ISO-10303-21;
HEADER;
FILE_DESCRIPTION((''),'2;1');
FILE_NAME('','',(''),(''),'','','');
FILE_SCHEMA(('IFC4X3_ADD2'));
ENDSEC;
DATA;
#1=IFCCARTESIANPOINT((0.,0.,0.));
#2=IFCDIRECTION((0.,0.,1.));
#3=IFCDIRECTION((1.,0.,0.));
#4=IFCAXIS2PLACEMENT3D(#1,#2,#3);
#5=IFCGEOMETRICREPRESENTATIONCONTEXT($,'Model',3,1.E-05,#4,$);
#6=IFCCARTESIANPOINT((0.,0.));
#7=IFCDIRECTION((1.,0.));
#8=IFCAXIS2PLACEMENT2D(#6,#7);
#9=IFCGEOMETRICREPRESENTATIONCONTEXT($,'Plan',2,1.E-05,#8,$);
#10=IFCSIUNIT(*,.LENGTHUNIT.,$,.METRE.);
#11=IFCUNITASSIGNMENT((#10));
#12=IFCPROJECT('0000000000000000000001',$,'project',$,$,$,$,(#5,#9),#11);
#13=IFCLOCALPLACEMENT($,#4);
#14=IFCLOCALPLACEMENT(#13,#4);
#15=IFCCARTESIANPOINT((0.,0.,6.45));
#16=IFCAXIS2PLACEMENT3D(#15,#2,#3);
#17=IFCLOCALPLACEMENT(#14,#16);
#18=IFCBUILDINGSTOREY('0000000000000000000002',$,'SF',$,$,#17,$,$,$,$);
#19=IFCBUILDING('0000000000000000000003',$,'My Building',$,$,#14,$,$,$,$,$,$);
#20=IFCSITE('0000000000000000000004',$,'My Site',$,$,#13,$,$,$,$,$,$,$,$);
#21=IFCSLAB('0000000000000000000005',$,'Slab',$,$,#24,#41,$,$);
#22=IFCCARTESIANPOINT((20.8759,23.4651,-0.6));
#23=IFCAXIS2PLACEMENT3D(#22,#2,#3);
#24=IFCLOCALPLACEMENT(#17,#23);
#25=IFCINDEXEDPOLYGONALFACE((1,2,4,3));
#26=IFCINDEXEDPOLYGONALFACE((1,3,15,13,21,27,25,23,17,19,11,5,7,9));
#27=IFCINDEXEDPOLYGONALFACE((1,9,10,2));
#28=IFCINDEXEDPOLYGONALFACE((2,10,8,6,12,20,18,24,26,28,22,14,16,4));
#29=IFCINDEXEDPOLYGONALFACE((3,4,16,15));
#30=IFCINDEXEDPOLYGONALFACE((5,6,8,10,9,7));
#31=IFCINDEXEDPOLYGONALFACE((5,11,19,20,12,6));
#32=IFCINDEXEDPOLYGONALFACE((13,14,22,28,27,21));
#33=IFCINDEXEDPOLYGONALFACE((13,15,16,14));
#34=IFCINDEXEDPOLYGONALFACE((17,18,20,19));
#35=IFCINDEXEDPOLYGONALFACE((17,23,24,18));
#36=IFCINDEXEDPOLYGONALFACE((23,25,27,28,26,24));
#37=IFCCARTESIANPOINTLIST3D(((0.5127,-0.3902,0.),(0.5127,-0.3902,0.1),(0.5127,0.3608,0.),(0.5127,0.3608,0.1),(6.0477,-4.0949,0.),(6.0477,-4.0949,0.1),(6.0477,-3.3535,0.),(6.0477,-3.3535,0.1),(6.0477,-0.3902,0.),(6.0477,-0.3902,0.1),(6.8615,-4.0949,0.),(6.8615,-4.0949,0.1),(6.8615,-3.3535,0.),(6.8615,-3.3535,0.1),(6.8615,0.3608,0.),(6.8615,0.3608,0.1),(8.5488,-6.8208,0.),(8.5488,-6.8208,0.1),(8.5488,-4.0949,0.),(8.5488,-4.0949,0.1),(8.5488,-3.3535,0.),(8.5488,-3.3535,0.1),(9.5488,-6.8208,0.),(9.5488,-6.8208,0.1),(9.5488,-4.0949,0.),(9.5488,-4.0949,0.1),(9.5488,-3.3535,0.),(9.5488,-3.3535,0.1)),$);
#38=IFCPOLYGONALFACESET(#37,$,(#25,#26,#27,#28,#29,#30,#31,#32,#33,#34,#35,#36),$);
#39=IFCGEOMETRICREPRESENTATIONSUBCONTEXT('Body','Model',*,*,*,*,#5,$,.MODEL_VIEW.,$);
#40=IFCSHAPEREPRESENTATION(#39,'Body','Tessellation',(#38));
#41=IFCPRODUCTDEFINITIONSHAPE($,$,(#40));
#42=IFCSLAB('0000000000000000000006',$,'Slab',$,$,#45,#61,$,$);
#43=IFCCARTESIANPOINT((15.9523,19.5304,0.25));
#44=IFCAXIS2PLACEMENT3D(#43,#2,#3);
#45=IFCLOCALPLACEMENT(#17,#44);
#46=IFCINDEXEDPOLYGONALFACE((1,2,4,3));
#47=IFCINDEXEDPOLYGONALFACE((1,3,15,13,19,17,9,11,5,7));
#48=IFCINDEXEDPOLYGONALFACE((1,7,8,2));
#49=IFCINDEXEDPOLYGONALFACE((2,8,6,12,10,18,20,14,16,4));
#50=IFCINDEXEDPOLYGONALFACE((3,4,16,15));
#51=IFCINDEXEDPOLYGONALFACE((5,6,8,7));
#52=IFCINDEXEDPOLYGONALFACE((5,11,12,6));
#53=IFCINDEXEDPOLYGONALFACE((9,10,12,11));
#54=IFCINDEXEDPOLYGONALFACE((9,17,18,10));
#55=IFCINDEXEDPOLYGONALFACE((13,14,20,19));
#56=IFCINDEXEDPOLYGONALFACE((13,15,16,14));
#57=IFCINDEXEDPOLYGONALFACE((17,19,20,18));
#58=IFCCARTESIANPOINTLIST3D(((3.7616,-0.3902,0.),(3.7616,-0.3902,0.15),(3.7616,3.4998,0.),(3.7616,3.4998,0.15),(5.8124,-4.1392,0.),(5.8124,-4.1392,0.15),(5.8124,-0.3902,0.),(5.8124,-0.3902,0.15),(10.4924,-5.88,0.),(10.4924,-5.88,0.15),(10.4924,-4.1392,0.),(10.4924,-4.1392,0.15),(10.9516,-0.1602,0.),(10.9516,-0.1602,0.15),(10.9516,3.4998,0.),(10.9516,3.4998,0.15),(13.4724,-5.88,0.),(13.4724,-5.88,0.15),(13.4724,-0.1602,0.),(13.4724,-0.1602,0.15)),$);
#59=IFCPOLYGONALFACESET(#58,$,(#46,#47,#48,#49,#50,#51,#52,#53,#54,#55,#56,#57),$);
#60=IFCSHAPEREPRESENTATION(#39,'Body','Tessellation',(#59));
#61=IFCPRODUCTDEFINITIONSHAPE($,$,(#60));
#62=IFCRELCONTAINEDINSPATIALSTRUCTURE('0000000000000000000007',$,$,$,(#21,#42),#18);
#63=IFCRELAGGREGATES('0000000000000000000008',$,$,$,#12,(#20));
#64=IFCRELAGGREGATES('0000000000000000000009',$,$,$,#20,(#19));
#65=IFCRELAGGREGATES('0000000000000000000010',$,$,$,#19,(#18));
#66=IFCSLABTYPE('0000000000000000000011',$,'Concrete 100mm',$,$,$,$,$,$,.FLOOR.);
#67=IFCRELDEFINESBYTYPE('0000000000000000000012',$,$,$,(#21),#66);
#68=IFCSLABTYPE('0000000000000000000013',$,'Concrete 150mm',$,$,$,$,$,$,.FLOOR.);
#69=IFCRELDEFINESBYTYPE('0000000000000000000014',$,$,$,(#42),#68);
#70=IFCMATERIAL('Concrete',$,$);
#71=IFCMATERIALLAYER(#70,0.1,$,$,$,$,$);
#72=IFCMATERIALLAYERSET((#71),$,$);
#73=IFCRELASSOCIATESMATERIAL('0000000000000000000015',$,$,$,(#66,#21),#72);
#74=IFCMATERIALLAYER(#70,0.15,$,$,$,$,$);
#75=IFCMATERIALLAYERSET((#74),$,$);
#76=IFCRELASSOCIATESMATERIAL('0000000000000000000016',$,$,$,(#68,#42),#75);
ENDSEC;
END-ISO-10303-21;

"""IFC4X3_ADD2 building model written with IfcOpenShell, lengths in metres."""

from ifc_helpers import new_model, si_unit, frame, origin_with_axes, origin_2d_with_axis, place, context, subcontext, project, spatial, line, indexed_curve, outline, extrude, material, layer, layer_set, layer_usage, type_object, element, save


model = new_model("IFC4X3_ADD2")

# Units and contexts
model_context = context("Model", 3, precision=1e-05, world=origin_with_axes())
plan_context = context("Plan", 2, precision=1e-05, world=origin_2d_with_axis())
body_context = subcontext(model_context, "Body", "Model", "MODEL_VIEW")
ifc_project = project(units=[si_unit("LENGTHUNIT", "METRE")], contexts=[model_context, plan_context])

# Site, building, storey
site_placement = place(None, origin_with_axes())
site = spatial("IfcSite", under=ifc_project, at=site_placement, Name="My Site")
building_placement = place(site_placement, origin_with_axes())
building = spatial("IfcBuilding", under=site, at=building_placement, Name="My Building")
storey_placement = place(building_placement, frame((0.0, 0.0, 6.45), z_axis=(0.0, 0.0, 1.0), x_axis=(1.0, 0.0, 0.0)))
storey = spatial("IfcBuildingStorey", under=building, at=storey_placement, Name="SF")

# Slabs
ifc_material = material(Name="Concrete")
ifc_layer_1 = layer(ifc_material, 0.1)
ifc_layer_set_1 = layer_set([ifc_layer_1])
ifc_layer_usage_1 = layer_usage(ifc_layer_set_1, "AXIS3", "POSITIVE", 0.0)
slab_type_1 = type_object("IfcSlabType", Name="Concrete 100mm", PredefinedType="FLOOR", material=ifc_layer_set_1)
slab_1_placement = place(storey_placement, frame((20.8759, 23.4651, -0.6), z_axis=(0.0, 0.0, 1.0), x_axis=(1.0, 0.0, 0.0)))
element("IfcSlab", 1, at=slab_1_placement, inside=storey, type_object=slab_type_1, material=ifc_layer_usage_1, Name="Slab", context=body_context, shape_type="SweptSolid", body=[
    extrude(outline(indexed_curve([(9.5488, -4.0949), (9.5488, -3.3535), (8.5488, -3.3535), (6.8615, -3.3535), (6.8615, 0.3608), (0.5127, 0.3608), (0.5127, -0.3902), (6.0477, -0.3902), (6.0477, -3.3535), (6.0477, -4.0949), (6.8615, -4.0949), (8.5488, -4.0949), (8.5488, -6.8208), (9.5488, -6.8208)], segments=[line(11, 12), line(12, 13), line(13, 14), line(14, 1), line(1, 2), line(2, 3), line(3, 4), line(4, 5), line(5, 6), line(6, 7), line(7, 8), line(8, 9), line(9, 10), line(10, 11)], self_intersect=False)), None, (0.0, 0.0, 1.0), 0.1),
])
ifc_layer_2 = layer(ifc_material, 0.15)
ifc_layer_set_2 = layer_set([ifc_layer_2])
ifc_layer_usage_2 = layer_usage(ifc_layer_set_2, "AXIS3", "POSITIVE", 0.0)
slab_type_2 = type_object("IfcSlabType", Name="Concrete 150mm", PredefinedType="FLOOR", material=ifc_layer_set_2)
slab_2_placement = place(storey_placement, frame((15.9523, 19.5304, 0.25), z_axis=(0.0, 0.0, 1.0), x_axis=(1.0, 0.0, 0.0)))
element("IfcSlab", 2, at=slab_2_placement, inside=storey, type_object=slab_type_2, material=ifc_layer_usage_2, Name="Slab", context=body_context, shape_type="SweptSolid", body=[
    extrude(outline(indexed_curve([(10.4924, -4.1392), (10.4924, -5.88), (13.4724, -5.88), (13.4724, -0.1602), (10.9516, -0.1602), (10.9516, 3.4998), (3.7616, 3.4998), (3.7616, -0.3902), (5.8124, -0.3902), (5.8124, -4.1392), (10.4924, -4.1392)])), None, (0.0, 0.0, 1.0), 0.15),
])

save(model, "model.ifc")
